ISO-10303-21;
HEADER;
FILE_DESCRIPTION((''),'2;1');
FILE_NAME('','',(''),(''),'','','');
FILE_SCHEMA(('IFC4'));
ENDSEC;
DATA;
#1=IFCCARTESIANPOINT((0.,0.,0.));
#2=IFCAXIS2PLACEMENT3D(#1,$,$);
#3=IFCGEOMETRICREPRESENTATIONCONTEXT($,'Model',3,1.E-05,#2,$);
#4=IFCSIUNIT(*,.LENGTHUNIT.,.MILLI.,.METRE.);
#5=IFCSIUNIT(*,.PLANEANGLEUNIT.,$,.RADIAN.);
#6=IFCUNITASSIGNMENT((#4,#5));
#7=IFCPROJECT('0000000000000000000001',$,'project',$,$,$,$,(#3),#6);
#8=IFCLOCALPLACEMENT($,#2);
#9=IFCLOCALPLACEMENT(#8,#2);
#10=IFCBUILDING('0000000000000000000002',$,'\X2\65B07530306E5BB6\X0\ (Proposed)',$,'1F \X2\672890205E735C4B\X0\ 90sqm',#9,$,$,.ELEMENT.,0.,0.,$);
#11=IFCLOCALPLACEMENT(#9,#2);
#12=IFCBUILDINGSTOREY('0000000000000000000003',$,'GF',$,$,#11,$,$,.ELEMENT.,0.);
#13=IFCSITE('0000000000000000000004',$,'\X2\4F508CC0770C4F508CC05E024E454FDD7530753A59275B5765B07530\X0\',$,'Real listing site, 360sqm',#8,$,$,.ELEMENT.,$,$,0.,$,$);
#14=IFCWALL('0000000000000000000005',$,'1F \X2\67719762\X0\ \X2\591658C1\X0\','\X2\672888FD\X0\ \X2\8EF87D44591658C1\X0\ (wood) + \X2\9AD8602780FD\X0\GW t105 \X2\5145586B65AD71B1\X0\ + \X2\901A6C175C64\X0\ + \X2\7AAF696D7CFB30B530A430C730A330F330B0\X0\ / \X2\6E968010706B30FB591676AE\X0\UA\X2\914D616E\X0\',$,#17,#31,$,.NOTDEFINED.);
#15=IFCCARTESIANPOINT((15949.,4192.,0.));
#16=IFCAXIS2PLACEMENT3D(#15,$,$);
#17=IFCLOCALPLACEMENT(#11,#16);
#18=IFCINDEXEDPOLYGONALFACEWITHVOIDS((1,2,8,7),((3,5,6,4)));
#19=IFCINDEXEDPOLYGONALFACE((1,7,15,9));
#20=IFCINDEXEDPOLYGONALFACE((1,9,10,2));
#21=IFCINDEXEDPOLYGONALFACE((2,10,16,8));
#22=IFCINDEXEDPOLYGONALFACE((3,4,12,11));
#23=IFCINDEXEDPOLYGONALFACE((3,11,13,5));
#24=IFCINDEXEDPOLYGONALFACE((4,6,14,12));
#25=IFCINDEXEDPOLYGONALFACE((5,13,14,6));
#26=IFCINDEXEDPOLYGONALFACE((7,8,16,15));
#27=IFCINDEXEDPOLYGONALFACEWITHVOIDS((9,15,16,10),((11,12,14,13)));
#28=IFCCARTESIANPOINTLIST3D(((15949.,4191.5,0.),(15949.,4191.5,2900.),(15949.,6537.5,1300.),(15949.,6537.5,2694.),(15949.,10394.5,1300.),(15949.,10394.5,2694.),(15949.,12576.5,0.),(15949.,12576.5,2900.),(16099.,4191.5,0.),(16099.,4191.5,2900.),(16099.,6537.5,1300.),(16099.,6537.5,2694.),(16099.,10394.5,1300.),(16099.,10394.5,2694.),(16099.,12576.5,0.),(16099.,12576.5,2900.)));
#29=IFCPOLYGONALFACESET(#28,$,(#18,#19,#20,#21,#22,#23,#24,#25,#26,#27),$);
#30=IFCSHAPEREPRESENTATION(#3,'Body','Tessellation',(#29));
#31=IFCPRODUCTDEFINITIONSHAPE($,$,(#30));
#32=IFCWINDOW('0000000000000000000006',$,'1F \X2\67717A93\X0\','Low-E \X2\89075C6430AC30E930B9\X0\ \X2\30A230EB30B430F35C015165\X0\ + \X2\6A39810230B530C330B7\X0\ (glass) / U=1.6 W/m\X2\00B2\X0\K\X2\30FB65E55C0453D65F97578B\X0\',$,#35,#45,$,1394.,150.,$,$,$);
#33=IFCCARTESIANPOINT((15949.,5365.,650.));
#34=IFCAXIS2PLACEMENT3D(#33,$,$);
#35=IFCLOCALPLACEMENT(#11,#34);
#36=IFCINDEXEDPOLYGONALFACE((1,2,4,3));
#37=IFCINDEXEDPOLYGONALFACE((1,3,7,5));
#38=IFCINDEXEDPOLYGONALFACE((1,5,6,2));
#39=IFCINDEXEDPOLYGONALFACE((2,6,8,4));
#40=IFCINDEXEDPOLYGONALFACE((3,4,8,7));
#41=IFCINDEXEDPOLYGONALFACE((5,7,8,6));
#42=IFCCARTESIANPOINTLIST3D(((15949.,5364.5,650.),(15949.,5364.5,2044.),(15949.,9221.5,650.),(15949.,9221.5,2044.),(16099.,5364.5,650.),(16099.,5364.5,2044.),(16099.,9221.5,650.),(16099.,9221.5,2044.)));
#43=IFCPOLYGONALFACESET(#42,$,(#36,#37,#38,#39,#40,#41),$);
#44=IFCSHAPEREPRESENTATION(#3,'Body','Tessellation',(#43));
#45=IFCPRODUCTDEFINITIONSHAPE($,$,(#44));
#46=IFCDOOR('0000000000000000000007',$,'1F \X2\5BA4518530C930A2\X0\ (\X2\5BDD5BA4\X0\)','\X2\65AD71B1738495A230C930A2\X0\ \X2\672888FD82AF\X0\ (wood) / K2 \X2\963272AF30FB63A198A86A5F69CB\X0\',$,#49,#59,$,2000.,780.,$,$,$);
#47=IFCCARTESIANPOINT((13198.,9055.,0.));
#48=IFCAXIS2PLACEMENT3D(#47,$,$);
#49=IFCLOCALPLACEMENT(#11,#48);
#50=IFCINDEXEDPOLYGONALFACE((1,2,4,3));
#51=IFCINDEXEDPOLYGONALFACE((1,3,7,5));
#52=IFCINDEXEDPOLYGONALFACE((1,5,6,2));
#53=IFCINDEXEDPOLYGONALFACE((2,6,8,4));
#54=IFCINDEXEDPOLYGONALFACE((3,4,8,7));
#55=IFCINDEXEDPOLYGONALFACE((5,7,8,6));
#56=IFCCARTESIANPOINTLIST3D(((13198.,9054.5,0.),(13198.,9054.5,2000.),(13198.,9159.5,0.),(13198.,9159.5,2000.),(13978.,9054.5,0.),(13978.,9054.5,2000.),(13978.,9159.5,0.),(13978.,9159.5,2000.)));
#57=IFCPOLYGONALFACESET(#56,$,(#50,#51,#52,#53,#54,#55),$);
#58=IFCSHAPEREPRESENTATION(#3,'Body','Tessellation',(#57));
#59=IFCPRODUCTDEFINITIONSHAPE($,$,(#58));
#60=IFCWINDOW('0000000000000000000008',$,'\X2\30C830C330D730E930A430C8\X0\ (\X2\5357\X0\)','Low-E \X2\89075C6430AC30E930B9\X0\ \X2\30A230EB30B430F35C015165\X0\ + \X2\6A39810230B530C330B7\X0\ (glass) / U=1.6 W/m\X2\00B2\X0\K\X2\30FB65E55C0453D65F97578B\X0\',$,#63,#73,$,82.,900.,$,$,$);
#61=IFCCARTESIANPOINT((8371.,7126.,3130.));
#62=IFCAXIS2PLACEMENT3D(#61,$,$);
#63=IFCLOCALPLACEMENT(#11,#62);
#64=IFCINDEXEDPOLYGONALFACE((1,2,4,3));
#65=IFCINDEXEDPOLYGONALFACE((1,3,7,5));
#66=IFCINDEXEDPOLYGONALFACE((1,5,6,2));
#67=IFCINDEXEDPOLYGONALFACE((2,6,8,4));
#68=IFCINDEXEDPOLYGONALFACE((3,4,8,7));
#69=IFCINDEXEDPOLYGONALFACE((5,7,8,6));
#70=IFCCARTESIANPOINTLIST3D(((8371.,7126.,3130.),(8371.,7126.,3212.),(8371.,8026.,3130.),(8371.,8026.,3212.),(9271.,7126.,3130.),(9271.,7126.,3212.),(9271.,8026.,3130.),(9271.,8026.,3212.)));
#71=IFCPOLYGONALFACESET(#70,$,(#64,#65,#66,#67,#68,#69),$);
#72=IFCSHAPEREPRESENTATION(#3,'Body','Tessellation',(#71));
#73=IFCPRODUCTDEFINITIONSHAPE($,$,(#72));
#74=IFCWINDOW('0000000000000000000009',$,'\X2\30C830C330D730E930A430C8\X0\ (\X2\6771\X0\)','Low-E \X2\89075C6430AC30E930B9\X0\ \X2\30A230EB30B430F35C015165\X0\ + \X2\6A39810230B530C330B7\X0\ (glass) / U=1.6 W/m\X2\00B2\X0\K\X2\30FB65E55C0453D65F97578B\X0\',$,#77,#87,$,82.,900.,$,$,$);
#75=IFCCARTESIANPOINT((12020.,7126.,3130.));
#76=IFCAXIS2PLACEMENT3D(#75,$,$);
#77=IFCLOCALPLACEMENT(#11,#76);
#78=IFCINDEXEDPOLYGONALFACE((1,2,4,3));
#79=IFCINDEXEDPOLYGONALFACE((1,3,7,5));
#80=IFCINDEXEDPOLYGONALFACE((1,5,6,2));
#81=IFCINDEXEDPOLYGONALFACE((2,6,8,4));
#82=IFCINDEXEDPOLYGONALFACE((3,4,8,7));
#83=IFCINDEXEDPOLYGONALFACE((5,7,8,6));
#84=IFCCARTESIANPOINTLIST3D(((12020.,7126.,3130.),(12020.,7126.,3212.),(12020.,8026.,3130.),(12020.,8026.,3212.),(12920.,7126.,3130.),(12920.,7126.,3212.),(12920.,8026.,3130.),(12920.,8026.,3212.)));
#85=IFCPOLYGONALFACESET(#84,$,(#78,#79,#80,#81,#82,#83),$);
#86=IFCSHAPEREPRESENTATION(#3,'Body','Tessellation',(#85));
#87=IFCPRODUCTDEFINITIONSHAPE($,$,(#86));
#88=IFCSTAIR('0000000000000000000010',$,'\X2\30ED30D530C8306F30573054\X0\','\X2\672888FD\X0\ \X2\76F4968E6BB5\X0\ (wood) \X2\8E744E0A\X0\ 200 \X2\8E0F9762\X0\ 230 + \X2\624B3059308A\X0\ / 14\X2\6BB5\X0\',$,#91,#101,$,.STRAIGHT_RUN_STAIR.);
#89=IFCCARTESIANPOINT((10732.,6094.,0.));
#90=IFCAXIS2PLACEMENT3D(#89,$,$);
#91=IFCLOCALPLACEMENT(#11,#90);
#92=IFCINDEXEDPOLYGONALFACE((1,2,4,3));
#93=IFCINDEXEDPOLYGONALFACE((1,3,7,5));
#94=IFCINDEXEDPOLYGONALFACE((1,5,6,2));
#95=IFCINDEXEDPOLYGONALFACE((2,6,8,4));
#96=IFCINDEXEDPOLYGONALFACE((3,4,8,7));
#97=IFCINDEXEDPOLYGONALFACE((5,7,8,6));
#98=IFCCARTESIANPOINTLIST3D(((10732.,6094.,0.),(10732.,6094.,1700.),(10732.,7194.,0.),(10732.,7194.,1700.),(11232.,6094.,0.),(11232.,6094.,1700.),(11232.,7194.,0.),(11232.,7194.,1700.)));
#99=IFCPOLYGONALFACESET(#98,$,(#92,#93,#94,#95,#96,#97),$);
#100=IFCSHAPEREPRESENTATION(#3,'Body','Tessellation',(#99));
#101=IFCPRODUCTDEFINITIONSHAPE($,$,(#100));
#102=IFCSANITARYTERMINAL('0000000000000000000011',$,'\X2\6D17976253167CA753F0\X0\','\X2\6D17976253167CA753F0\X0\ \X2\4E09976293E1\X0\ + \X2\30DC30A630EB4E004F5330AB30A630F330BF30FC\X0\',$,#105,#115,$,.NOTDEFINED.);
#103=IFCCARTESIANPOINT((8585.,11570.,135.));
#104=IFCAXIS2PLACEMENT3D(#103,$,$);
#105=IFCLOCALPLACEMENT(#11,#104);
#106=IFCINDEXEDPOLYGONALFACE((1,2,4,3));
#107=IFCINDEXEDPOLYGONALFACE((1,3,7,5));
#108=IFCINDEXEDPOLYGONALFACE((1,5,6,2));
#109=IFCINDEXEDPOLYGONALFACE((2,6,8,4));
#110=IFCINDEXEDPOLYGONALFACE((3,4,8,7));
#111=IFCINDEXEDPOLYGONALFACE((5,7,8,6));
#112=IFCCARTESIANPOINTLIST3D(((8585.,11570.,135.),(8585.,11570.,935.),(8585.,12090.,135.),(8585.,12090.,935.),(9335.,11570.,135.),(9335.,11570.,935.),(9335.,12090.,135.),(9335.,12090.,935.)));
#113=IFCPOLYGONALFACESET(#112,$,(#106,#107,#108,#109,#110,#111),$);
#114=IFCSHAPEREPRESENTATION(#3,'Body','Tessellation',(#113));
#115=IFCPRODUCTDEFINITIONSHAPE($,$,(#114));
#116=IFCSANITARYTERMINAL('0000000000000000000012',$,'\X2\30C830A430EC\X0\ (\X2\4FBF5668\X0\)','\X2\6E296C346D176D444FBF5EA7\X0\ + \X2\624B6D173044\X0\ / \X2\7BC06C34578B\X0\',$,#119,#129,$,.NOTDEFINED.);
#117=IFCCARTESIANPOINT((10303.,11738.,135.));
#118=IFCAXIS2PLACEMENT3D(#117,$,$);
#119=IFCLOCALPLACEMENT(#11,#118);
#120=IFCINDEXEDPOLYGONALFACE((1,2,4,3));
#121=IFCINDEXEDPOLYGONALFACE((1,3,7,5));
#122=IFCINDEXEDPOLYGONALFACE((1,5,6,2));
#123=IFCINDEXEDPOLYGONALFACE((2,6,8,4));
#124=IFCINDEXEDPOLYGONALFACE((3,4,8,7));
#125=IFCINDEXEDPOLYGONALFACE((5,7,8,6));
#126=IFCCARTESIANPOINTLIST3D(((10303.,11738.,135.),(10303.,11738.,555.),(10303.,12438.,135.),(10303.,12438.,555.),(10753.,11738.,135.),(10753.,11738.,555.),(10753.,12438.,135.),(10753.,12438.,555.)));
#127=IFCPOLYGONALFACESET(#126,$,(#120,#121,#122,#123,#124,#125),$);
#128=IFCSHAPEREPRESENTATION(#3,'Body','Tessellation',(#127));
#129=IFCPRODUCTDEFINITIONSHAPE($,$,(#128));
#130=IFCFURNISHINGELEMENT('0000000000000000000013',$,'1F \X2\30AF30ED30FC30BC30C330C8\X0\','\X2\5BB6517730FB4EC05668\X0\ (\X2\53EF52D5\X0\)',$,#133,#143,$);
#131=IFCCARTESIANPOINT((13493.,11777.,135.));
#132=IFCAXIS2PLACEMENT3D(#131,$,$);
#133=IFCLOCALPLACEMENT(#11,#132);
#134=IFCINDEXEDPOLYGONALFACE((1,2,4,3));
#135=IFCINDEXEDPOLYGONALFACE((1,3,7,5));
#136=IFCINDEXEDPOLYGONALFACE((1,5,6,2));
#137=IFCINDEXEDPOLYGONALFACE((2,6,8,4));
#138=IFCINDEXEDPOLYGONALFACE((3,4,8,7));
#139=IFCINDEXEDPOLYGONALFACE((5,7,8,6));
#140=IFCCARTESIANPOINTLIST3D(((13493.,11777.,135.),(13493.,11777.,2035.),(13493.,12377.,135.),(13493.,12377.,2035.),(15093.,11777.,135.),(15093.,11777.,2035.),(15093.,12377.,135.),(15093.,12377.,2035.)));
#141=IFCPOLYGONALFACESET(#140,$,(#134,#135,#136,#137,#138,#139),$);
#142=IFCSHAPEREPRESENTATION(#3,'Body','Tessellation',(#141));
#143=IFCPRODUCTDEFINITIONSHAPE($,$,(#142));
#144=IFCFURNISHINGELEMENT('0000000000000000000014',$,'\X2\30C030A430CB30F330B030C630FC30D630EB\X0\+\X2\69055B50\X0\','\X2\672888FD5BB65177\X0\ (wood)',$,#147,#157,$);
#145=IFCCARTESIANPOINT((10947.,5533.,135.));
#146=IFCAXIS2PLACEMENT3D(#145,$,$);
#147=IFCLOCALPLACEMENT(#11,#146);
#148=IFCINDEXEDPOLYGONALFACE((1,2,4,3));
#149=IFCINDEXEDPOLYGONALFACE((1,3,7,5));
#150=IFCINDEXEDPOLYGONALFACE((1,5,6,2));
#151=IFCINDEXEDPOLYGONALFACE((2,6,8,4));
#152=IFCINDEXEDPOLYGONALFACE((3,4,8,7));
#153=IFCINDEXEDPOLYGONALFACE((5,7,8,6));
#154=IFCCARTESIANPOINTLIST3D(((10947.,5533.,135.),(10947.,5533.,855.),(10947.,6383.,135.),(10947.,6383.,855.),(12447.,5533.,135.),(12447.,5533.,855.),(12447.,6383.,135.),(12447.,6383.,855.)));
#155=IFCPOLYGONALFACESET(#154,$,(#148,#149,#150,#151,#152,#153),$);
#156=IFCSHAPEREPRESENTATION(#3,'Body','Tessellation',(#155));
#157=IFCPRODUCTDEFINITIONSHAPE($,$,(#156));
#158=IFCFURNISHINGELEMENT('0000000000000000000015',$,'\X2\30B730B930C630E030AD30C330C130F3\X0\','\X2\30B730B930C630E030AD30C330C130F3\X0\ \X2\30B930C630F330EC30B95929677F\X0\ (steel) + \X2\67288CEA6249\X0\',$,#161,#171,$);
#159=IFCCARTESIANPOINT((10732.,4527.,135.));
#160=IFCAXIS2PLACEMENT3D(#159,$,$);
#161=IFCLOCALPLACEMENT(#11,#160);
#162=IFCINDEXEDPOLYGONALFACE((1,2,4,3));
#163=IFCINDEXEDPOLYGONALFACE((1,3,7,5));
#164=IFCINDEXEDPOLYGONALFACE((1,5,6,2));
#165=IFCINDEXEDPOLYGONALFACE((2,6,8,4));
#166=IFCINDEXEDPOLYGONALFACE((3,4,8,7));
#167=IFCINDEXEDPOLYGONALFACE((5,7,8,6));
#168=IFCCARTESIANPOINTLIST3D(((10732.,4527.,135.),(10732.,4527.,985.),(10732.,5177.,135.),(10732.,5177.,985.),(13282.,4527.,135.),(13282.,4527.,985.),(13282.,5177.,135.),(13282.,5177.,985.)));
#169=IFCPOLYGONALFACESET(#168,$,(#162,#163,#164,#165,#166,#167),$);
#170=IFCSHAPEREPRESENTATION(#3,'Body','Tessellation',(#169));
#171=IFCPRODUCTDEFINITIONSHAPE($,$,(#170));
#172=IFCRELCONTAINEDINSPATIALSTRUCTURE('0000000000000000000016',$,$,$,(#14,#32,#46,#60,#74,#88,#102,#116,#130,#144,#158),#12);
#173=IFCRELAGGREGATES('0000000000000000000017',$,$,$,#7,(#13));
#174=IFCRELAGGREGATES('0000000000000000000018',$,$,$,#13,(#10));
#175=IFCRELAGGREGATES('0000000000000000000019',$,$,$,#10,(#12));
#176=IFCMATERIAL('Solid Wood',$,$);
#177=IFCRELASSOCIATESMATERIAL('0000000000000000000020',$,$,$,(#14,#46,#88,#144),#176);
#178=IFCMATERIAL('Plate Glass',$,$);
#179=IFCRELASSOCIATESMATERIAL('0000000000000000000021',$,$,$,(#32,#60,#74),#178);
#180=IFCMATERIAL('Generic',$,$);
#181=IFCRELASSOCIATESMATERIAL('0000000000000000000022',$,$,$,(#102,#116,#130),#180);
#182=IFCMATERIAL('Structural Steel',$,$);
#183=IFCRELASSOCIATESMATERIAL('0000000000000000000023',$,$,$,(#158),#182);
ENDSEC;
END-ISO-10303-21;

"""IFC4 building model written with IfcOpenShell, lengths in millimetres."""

from ifc_helpers import new_model, si_unit, frame, frame_2d, origin, place, context, project, spatial, rectangle, extrude, material, element, fill, save


model = new_model("IFC4")

# Units and contexts
model_context = context("Model", 3, precision=1e-05, world=origin())
ifc_project = project(units=[si_unit("LENGTHUNIT", "METRE", prefix="MILLI"), si_unit("PLANEANGLEUNIT", "RADIAN")], contexts=[model_context])

# Site, building, storey
site_placement = place(None, origin())
site = spatial("IfcSite", under=ifc_project, at=site_placement, Name="佐賀県佐賀市久保田町大字新田", ObjectType="Real listing site, 360sqm", CompositionType="ELEMENT", RefElevation=0.0)
building_placement = place(site_placement, origin())
building = spatial("IfcBuilding", under=site, at=building_placement, Name="新田の家 (Proposed)", ObjectType="1F 木造平屋 90sqm", CompositionType="ELEMENT", ElevationOfRefHeight=0.0, ElevationOfTerrain=0.0)
storey_placement = place(building_placement, origin())
storey = spatial("IfcBuildingStorey", under=building, at=storey_placement, Name="GF", CompositionType="ELEMENT", Elevation=0.0)

# Wall, opening, window
ifc_material_1 = material(Name="Solid Wood")
wall_1_placement = place(storey_placement, frame((15949.0, 4192.0, 0.0)))
wall_1 = element("IfcWall", 1, at=wall_1_placement, inside=storey, material=ifc_material_1, Name="1F 東面 外壁", Description="木製 軸組外壁 (wood) + 高性能GW t105 充填断熱 + 通気層 + 窯業系サイディング / 準耐火・外皮UA配慮", PredefinedType="NOTDEFINED", context=model_context, shape_type="SweptSolid", body=[
    extrude(rectangle(XDim=150.0, YDim=8385.0, at=frame_2d((75.0, 4192.0))), frame((15949.0, 4192.0, 0.0)), (0.0, 0.0, 1.0), 2900.0),
])
opening_placement = place(storey_placement, frame((15949.0, 5365.0, 650.0)))
opening = element("IfcOpeningElement", 2, at=opening_placement, cuts=wall_1, PredefinedType="NOTDEFINED", context=model_context, shape_type="SweptSolid", body=[
    extrude(rectangle(XDim=150.0, YDim=3857.0, at=frame_2d((75.0, 1928.0))), frame((15949.0, 5365.0, 650.0)), (0.0, 0.0, 1.0), 1394.0),
])
ifc_material_2 = material(Name="Plate Glass")
window_1_placement = place(storey_placement, frame((15949.0, 5365.0, 650.0)))
window_1 = element("IfcWindow", 3, at=window_1_placement, inside=storey, material=ifc_material_2, Name="1F 東窓", Description="Low-E 複層ガラス アルゴン封入 + 樹脂サッシ (glass) / U=1.6 W/m²K・日射取得型", OverallHeight=1394.0, OverallWidth=150.0, context=model_context, shape_type="SweptSolid", body=[
    extrude(rectangle(XDim=150.0, YDim=3857.0, at=frame_2d((75.0, 1928.0))), frame((15949.0, 5365.0, 650.0)), (0.0, 0.0, 1.0), 1394.0),
])
fill(opening, window_1)

# Door
door_placement = place(storey_placement, frame((13198.0, 9055.0, 0.0)))
element("IfcDoor", 4, at=door_placement, inside=storey, material=ifc_material_1, Name="1F 室内ドア (寝室)", Description="断熱玄関ドア 木製芯 (wood) / K2 防犯・採風機構", OverallHeight=2000.0, OverallWidth=780.0, context=model_context, shape_type="SweptSolid", body=[
    extrude(rectangle(XDim=780.0, YDim=105.0, at=frame_2d((390.0, 52.0))), frame((13198.0, 9055.0, 0.0)), (0.0, 0.0, 1.0), 2000.0),
])

# Windows
window_2_placement = place(storey_placement, frame((8371.0, 7126.0, 3130.0)))
element("IfcWindow", 5, at=window_2_placement, inside=storey, material=ifc_material_2, Name="トップライト (南)", Description="Low-E 複層ガラス アルゴン封入 + 樹脂サッシ (glass) / U=1.6 W/m²K・日射取得型", OverallHeight=82.0, OverallWidth=900.0, context=model_context, shape_type="SweptSolid", body=[
    extrude(rectangle(XDim=900.0, YDim=900.0, at=frame_2d((450.0, 450.0))), frame((8371.0, 7126.0, 3130.0)), (0.0, 0.0, 1.0), 82.0),
])
window_3_placement = place(storey_placement, frame((12020.0, 7126.0, 3130.0)))
element("IfcWindow", 6, at=window_3_placement, inside=storey, material=ifc_material_2, Name="トップライト (東)", Description="Low-E 複層ガラス アルゴン封入 + 樹脂サッシ (glass) / U=1.6 W/m²K・日射取得型", OverallHeight=82.0, OverallWidth=900.0, context=model_context, shape_type="SweptSolid", body=[
    extrude(rectangle(XDim=900.0, YDim=900.0, at=frame_2d((450.0, 450.0))), frame((12020.0, 7126.0, 3130.0)), (0.0, 0.0, 1.0), 82.0),
])

# Stair
stair_placement = place(storey_placement, frame((10732.0, 6094.0, 0.0)))
element("IfcStair", 7, at=stair_placement, inside=storey, material=ifc_material_1, Name="ロフトはしご", Description="木製 直階段 (wood) 蹴上 200 踏面 230 + 手すり / 14段", PredefinedType="STRAIGHT_RUN_STAIR", context=model_context, shape_type="SweptSolid", body=[
    extrude(rectangle(XDim=500.0, YDim=1100.0, at=frame_2d((250.0, 550.0))), frame((10732.0, 6094.0, 0.0)), (0.0, 0.0, 1.0), 1700.0),
])

# Sanitary terminals
ifc_material_3 = material(Name="Generic")
sanitary_terminal_1_placement = place(storey_placement, frame((8585.0, 11570.0, 135.0)))
element("IfcSanitaryTerminal", 8, at=sanitary_terminal_1_placement, inside=storey, material=ifc_material_3, Name="洗面化粧台", Description="洗面化粧台 三面鏡 + ボウル一体カウンター", PredefinedType="NOTDEFINED", context=model_context, shape_type="SweptSolid", body=[
    extrude(rectangle(XDim=750.0, YDim=520.0, at=frame_2d((375.0, 260.0))), frame((8585.0, 11570.0, 135.0)), (0.0, 0.0, 1.0), 800.0),
])
sanitary_terminal_2_placement = place(storey_placement, frame((10303.0, 11738.0, 135.0)))
element("IfcSanitaryTerminal", 9, at=sanitary_terminal_2_placement, inside=storey, material=ifc_material_3, Name="トイレ (便器)", Description="温水洗浄便座 + 手洗い / 節水型", PredefinedType="NOTDEFINED", context=model_context, shape_type="SweptSolid", body=[
    extrude(rectangle(XDim=450.0, YDim=700.0, at=frame_2d((225.0, 350.0))), frame((10303.0, 11738.0, 135.0)), (0.0, 0.0, 1.0), 420.0),
])

# Furnishing elements
furnishing_1_placement = place(storey_placement, frame((13493.0, 11777.0, 135.0)))
element("IfcFurnishingElement", 10, at=furnishing_1_placement, inside=storey, material=ifc_material_3, Name="1F クローゼット", Description="家具・什器 (可動)", context=model_context, shape_type="SweptSolid", body=[
    extrude(rectangle(XDim=1600.0, YDim=600.0, at=frame_2d((800.0, 300.0))), frame((13493.0, 11777.0, 135.0)), (0.0, 0.0, 1.0), 1900.0),
])
furnishing_2_placement = place(storey_placement, frame((10947.0, 5533.0, 135.0)))
element("IfcFurnishingElement", 11, at=furnishing_2_placement, inside=storey, material=ifc_material_1, Name="ダイニングテーブル+椅子", Description="木製家具 (wood)", context=model_context, shape_type="SweptSolid", body=[
    extrude(rectangle(XDim=1500.0, YDim=850.0, at=frame_2d((750.0, 425.0))), frame((10947.0, 5533.0, 135.0)), (0.0, 0.0, 1.0), 720.0),
])
ifc_material_4 = material(Name="Structural Steel")
furnishing_3_placement = place(storey_placement, frame((10732.0, 4527.0, 135.0)))
element("IfcFurnishingElement", 12, at=furnishing_3_placement, inside=storey, material=ifc_material_4, Name="システムキッチン", Description="システムキッチン ステンレス天板 (steel) + 木質扉", context=model_context, shape_type="SweptSolid", body=[
    extrude(rectangle(XDim=2550.0, YDim=650.0, at=frame_2d((1275.0, 325.0))), frame((10732.0, 4527.0, 135.0)), (0.0, 0.0, 1.0), 850.0),
])

save(model, "model.ifc")
